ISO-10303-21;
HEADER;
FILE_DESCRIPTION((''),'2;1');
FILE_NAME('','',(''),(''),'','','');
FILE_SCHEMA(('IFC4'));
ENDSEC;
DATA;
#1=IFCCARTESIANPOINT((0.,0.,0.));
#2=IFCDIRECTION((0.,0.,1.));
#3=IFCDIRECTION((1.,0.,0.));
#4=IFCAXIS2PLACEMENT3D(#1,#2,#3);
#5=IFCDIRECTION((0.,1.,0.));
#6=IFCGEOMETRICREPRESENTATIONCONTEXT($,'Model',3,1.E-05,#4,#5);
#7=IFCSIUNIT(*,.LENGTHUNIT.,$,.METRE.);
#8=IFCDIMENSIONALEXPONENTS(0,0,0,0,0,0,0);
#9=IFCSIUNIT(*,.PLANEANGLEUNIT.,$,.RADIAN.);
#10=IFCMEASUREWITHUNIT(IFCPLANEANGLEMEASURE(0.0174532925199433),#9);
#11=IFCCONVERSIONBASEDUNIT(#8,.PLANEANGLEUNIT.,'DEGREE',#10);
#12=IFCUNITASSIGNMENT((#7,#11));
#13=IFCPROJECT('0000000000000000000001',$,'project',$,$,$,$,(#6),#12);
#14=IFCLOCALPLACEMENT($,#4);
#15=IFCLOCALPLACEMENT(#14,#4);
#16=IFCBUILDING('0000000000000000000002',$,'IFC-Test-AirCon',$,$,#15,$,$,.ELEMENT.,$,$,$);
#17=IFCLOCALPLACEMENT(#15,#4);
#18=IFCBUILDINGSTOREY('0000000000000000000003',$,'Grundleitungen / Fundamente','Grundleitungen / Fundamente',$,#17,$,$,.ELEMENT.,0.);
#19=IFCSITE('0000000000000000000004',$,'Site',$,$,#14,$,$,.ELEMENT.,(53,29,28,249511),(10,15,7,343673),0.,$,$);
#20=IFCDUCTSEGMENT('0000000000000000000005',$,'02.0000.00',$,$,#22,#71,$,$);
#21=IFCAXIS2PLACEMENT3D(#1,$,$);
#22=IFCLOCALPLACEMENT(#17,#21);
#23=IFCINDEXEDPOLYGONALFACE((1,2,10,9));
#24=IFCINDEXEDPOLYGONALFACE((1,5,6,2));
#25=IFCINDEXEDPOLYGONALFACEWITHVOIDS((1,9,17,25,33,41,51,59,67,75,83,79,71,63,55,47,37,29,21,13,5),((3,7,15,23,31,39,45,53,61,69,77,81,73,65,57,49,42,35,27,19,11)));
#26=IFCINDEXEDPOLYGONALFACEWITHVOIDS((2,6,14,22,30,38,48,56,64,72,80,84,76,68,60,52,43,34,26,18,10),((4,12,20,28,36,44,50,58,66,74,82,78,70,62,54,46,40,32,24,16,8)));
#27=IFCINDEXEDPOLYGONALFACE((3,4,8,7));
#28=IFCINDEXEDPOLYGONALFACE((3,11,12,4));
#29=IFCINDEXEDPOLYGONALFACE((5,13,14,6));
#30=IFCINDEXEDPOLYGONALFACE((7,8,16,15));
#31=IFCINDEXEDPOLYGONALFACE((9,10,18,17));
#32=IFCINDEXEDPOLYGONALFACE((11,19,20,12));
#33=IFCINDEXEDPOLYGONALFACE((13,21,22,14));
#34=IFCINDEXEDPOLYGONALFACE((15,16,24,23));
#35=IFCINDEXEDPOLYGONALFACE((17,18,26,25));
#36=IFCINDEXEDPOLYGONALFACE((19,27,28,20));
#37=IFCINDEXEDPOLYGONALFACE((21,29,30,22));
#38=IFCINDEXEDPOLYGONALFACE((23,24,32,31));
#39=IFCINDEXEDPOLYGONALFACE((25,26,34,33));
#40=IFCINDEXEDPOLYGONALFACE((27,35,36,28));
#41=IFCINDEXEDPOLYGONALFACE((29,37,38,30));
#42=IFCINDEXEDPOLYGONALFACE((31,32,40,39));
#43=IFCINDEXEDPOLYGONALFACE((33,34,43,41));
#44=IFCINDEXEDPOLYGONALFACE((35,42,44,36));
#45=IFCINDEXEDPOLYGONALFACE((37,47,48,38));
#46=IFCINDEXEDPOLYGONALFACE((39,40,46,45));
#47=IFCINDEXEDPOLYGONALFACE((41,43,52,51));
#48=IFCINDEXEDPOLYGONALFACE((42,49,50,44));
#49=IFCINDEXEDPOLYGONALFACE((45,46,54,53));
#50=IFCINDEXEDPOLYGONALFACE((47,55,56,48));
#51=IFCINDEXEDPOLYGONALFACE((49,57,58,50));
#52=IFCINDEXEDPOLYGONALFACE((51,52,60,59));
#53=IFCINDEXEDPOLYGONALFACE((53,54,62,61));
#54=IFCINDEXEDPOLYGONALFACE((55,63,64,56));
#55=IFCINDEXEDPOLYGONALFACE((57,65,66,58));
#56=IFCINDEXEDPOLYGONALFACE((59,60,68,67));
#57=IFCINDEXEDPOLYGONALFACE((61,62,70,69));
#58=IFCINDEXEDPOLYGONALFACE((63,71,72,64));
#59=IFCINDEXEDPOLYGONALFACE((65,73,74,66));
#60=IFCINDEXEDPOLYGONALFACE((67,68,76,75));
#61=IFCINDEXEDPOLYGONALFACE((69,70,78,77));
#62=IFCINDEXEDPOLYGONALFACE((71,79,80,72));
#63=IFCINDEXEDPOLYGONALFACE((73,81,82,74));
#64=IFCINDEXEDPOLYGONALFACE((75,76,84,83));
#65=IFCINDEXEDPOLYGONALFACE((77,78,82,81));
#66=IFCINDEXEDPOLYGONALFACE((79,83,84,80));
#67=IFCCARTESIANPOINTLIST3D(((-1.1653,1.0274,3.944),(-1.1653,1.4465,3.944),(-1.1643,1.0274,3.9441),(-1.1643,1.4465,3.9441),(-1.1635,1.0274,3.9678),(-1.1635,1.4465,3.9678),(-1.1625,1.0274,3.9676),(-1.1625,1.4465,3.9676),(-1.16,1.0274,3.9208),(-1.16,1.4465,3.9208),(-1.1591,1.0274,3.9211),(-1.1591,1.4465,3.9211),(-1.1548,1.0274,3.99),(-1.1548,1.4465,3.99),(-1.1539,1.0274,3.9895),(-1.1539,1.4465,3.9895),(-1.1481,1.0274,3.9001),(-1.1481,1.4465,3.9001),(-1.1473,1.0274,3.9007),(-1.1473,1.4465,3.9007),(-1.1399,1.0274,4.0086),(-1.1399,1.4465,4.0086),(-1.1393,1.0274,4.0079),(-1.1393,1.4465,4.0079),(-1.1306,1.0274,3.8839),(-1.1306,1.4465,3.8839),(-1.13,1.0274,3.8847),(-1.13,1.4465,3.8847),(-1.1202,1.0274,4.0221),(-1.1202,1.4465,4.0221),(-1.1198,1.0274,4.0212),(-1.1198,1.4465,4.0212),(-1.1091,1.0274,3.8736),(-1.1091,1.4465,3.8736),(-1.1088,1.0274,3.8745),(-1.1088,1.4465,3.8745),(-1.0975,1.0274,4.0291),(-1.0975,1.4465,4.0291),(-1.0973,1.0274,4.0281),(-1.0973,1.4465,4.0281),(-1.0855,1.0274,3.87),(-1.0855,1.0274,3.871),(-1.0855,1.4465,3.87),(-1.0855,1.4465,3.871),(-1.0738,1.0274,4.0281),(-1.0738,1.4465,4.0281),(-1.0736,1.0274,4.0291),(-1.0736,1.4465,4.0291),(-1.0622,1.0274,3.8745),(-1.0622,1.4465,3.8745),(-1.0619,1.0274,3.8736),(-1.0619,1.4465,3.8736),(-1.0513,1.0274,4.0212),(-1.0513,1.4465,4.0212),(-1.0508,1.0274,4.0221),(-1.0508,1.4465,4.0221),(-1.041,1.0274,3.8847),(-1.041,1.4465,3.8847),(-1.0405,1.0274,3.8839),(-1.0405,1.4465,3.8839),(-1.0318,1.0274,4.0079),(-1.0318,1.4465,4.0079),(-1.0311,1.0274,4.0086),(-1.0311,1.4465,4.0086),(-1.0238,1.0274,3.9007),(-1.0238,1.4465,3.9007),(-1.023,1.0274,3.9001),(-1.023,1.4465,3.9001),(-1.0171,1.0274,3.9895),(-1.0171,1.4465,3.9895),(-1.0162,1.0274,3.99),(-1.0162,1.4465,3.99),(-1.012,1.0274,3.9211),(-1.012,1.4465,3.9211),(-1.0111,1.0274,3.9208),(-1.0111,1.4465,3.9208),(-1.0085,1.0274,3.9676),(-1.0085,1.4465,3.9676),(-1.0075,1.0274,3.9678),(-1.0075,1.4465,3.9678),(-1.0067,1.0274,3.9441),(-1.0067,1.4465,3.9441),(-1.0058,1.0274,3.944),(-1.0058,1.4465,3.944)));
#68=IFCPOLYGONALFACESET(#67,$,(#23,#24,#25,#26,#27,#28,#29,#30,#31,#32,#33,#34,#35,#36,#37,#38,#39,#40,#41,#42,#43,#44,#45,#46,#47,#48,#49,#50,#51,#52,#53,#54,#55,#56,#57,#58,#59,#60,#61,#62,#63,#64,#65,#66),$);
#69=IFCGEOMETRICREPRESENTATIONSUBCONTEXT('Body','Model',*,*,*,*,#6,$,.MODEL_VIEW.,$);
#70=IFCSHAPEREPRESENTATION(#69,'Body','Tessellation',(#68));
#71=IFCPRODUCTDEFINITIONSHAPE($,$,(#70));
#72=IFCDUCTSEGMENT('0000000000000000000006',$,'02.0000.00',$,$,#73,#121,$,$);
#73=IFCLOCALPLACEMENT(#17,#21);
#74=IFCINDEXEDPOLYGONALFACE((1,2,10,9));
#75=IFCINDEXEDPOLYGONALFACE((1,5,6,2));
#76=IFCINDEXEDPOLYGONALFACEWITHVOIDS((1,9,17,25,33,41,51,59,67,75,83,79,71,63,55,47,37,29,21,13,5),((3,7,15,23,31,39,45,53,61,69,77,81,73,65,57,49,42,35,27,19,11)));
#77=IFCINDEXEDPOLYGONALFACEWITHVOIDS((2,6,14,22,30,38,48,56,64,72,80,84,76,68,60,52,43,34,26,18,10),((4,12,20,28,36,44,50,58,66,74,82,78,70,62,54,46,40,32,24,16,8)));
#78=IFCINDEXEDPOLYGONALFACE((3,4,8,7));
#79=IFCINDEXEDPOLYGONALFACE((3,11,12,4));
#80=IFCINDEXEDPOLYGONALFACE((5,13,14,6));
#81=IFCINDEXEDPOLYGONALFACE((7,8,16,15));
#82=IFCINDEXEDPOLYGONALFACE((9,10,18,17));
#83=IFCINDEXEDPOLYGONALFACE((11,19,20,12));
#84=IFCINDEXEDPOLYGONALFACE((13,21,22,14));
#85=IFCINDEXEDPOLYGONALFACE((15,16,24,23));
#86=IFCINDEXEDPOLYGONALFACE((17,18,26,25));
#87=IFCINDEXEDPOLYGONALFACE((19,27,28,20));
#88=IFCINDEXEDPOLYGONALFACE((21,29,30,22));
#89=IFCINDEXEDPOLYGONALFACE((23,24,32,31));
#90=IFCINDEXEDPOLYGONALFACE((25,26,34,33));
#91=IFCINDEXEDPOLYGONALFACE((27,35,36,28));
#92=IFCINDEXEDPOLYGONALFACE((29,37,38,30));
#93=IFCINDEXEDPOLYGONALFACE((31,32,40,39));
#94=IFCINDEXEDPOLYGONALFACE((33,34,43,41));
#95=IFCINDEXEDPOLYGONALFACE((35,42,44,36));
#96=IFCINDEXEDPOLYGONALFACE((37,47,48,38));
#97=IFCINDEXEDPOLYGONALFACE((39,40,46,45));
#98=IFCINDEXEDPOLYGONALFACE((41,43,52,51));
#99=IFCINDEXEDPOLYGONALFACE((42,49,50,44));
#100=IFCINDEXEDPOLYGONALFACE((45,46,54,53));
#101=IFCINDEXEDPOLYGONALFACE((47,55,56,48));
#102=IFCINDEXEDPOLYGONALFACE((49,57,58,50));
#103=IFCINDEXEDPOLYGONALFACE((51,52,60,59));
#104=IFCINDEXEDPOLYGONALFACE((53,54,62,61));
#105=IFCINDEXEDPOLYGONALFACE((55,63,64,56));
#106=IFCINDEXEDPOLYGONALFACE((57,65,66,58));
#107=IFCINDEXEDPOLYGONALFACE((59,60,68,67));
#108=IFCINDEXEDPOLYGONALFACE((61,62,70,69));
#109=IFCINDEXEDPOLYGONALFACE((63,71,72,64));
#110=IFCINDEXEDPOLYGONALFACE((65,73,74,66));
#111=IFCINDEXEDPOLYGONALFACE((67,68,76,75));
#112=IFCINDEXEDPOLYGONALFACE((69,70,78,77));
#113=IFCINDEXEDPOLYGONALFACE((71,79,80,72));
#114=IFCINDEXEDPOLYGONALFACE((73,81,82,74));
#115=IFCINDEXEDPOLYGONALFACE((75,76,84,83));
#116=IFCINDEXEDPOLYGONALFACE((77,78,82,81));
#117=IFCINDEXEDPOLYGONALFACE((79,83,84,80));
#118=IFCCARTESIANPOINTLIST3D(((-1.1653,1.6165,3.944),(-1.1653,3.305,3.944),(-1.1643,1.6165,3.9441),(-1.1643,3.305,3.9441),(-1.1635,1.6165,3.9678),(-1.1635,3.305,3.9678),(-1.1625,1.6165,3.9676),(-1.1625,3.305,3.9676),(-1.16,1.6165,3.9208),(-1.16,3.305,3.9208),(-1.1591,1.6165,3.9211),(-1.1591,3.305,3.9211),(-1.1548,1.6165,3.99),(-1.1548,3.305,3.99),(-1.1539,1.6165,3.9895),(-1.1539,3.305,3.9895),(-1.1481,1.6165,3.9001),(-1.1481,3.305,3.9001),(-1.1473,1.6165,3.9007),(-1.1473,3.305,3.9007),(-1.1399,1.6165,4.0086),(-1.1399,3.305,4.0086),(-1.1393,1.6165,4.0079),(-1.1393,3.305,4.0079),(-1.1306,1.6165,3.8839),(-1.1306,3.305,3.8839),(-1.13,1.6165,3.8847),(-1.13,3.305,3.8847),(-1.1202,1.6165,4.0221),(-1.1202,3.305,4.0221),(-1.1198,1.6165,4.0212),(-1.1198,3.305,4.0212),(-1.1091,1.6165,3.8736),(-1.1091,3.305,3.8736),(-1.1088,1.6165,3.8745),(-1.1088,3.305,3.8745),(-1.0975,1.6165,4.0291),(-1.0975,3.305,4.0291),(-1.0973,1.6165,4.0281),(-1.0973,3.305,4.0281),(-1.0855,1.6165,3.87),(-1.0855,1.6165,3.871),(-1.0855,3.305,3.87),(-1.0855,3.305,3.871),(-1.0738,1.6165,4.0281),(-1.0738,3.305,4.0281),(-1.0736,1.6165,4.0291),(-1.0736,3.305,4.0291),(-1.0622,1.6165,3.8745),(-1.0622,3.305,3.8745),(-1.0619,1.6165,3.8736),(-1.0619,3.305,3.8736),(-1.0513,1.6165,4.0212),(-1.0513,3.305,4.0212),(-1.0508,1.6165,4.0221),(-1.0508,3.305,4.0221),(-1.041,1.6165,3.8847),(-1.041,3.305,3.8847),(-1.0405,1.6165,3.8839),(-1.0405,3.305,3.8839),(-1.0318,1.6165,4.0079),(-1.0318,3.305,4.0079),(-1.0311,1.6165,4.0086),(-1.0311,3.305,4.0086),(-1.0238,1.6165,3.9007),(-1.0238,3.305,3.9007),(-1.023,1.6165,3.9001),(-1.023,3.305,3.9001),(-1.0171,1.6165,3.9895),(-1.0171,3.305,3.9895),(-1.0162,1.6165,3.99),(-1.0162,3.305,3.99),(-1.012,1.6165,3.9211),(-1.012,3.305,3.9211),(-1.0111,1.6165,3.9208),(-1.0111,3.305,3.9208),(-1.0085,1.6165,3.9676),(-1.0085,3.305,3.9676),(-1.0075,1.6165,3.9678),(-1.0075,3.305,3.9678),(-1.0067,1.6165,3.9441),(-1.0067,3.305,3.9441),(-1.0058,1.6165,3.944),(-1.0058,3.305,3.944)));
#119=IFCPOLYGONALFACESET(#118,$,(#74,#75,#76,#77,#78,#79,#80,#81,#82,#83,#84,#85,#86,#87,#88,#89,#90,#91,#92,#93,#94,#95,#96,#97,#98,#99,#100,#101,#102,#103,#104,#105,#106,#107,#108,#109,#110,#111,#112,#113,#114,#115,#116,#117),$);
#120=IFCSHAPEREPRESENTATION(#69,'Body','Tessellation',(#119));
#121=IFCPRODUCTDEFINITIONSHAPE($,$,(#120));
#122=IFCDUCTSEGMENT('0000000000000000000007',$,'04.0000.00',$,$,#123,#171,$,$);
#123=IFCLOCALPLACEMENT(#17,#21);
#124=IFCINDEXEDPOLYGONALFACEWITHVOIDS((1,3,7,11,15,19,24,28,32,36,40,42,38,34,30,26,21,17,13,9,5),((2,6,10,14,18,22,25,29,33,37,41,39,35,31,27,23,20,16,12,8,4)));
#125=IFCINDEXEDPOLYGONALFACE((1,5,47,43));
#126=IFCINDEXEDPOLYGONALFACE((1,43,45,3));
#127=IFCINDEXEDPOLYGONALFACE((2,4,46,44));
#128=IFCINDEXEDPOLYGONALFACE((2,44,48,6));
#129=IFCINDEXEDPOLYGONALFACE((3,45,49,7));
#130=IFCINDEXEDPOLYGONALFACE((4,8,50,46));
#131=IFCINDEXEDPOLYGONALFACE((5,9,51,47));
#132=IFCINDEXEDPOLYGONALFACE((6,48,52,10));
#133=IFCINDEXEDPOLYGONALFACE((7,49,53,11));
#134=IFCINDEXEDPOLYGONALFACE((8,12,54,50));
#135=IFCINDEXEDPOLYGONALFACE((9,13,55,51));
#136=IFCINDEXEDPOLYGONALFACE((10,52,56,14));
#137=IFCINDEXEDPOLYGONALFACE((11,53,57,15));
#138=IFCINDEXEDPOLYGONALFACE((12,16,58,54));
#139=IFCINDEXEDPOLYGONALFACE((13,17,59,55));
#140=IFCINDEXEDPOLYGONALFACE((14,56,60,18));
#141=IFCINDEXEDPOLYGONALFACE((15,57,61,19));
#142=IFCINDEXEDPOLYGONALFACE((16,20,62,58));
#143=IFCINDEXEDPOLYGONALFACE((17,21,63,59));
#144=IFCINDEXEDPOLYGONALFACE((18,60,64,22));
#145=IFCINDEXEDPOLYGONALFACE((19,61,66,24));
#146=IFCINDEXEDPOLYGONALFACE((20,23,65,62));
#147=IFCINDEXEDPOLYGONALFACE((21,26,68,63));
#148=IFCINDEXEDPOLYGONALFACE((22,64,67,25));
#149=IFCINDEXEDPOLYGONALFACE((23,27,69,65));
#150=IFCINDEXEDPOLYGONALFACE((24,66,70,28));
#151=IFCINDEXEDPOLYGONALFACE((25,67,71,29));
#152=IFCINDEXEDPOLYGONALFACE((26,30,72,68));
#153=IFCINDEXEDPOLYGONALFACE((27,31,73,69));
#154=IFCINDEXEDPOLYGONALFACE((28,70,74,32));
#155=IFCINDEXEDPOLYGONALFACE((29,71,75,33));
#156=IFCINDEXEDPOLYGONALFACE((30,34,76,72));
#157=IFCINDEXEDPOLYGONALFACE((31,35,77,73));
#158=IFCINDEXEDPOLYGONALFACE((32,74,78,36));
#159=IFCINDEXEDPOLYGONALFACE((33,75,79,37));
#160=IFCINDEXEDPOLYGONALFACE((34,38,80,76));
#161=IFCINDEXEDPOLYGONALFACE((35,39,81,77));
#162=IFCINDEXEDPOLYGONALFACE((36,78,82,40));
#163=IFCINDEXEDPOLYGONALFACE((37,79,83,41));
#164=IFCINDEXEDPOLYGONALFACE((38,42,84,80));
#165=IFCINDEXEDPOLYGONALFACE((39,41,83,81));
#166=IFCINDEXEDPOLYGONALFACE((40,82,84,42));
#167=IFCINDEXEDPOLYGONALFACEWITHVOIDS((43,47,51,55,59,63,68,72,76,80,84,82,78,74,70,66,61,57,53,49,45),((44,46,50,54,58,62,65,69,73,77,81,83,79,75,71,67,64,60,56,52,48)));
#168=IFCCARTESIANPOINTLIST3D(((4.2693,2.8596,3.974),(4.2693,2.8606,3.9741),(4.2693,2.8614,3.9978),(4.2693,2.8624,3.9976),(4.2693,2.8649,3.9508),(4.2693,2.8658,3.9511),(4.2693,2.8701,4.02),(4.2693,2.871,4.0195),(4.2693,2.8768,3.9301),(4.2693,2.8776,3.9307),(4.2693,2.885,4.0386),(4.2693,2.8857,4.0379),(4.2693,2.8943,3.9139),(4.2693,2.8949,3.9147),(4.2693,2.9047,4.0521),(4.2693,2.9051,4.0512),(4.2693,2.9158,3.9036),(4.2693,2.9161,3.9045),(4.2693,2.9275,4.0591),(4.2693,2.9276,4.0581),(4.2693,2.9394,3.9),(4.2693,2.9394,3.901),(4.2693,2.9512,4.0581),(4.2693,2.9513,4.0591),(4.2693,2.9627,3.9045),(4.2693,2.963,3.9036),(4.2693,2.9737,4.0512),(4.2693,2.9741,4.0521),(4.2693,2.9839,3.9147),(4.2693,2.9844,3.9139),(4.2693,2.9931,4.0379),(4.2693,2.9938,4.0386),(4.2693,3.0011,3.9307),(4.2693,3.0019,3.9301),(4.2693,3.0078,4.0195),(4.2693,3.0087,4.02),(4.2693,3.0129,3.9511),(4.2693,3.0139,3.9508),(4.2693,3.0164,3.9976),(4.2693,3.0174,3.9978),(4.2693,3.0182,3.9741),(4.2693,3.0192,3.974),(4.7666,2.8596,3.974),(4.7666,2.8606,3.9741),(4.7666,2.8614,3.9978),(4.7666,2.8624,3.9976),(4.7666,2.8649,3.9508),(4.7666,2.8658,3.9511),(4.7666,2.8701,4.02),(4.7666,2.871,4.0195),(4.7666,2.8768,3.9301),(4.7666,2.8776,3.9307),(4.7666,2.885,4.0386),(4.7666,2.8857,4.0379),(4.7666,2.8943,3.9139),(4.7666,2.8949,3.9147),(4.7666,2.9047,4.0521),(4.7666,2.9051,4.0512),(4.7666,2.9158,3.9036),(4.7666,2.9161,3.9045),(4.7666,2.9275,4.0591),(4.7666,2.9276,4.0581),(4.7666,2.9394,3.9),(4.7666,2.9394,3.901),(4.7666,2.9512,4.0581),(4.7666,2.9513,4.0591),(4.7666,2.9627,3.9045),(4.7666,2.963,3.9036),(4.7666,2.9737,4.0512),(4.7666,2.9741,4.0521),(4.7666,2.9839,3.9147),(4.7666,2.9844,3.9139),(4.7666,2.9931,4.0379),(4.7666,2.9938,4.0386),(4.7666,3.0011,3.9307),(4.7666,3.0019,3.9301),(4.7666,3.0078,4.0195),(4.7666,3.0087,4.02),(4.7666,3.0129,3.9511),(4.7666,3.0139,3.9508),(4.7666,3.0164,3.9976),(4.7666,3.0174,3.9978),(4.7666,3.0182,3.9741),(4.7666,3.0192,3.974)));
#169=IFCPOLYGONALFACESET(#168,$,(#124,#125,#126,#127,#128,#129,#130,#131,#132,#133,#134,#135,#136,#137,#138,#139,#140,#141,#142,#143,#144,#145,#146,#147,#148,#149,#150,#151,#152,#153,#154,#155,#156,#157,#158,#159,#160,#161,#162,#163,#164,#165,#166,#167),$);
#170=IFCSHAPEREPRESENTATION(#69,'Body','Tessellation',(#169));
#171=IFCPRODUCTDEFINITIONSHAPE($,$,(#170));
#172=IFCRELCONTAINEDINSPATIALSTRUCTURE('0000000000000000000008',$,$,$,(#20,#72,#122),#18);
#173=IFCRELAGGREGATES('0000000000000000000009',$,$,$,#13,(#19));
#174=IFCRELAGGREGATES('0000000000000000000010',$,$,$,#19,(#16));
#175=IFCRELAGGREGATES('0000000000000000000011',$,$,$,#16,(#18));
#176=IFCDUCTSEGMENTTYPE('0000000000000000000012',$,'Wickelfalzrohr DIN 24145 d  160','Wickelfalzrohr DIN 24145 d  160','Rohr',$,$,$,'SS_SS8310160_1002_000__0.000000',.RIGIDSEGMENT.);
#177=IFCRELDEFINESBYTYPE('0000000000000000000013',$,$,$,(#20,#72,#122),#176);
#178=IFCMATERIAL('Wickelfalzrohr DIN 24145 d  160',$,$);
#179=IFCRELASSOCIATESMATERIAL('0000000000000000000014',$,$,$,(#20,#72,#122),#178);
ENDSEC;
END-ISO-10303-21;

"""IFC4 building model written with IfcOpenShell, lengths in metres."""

from ifc_helpers import new_model, entity, si_unit, converted_unit, direction, frame, origin_with_axes, origin_2d_with_axis, place, context, subcontext, project, spatial, hollow_circle, extrude, material, type_object, element, save


model = new_model("IFC4")

# Units and contexts
model_context = context("Model", 3, precision=1e-05, world=origin_with_axes(), true_north=direction((0.0, 1.0, 0.0)))
body_context = subcontext(model_context, "Body", "Model", "MODEL_VIEW")
ifc_project = project(units=[si_unit("LENGTHUNIT", "METRE"), converted_unit("PLANEANGLEUNIT", "DEGREE", entity("IfcPlaneAngleMeasure", 0.0174532925199433), si_unit("PLANEANGLEUNIT", "RADIAN"), dimensions=[0, 0, 0, 0, 0, 0, 0])], contexts=[model_context])

# Site, building, storey
site_placement = place(None, origin_with_axes())
site = spatial("IfcSite", under=ifc_project, at=site_placement, Name="Site", CompositionType="ELEMENT", RefLatitude=(53, 29, 28, 249511), RefLongitude=(10, 15, 7, 343673), RefElevation=0.0)
building_placement = place(site_placement, origin_with_axes())
building = spatial("IfcBuilding", under=site, at=building_placement, Name="IFC-Test-AirCon", CompositionType="ELEMENT")
storey_placement = place(building_placement, origin_with_axes())
storey = spatial("IfcBuildingStorey", under=building, at=storey_placement, Name="Grundleitungen / Fundamente", Description="Grundleitungen / Fundamente", CompositionType="ELEMENT", Elevation=0.0)

# Duct segments
ifc_material_1 = material(Name="Wickelfalzrohr DIN 24145 d  160")
duct_segment_type_1 = type_object("IfcDuctSegmentType", Name="Wickelfalzrohr DIN 24145 d  160", Description="Wickelfalzrohr DIN 24145 d  160", ApplicableOccurrence="Rohr", ElementType="SS_SS8310160_1002_000__0.000000", PredefinedType="RIGIDSEGMENT")
duct_segment_1_placement = place(storey_placement, frame((-1.0855, 1.0274, 3.95), z_axis=(0.0, 0.0, 1.0), x_axis=(0.0, 1.0, 0.0)))
element("IfcDuctSegment", 1, at=duct_segment_1_placement, inside=storey, type_object=duct_segment_type_1, material=ifc_material_1, Name="02.0000.00", context=body_context, shape_type="SweptSolid", body=[
    extrude(hollow_circle(Radius=0.08, WallThickness=0.001, at=origin_2d_with_axis()), frame((0.0, 0.0, 0.0), z_axis=(1.0, 0.0, 0.0), x_axis=(0.0, 0.0, -1.0)), (0.0, 0.0, 1.0), 0.419),
])
duct_segment_2_placement = place(storey_placement, frame((-1.0855, 1.6165, 3.95), z_axis=(0.0, 0.0, 1.0), x_axis=(0.0, 1.0, 0.0)))
element("IfcDuctSegment", 2, at=duct_segment_2_placement, inside=storey, type_object=duct_segment_type_1, material=ifc_material_1, Name="02.0000.00", context=body_context, shape_type="SweptSolid", body=[
    extrude(hollow_circle(Radius=0.08, WallThickness=0.001, at=origin_2d_with_axis()), frame((0.0, 0.0, 0.0), z_axis=(1.0, 0.0, 0.0), x_axis=(0.0, 0.0, -1.0)), (0.0, 0.0, 1.0), 1.6885),
])
duct_segment_3_placement = place(storey_placement, frame((4.7666, 2.9394, 3.98), z_axis=(0.0, 0.0, 1.0), x_axis=(-1.0, 0.0, 0.0)))
element("IfcDuctSegment", 3, at=duct_segment_3_placement, inside=storey, type_object=duct_segment_type_1, material=ifc_material_1, Name="04.0000.00", context=body_context, shape_type="SweptSolid", body=[
    extrude(hollow_circle(Radius=0.08, WallThickness=0.001, at=origin_2d_with_axis()), frame((0.0, 0.0, 0.0), z_axis=(1.0, 0.0, 0.0), x_axis=(0.0, 0.0, -1.0)), (0.0, 0.0, 1.0), 0.4973),
])

save(model, "model.ifc")
